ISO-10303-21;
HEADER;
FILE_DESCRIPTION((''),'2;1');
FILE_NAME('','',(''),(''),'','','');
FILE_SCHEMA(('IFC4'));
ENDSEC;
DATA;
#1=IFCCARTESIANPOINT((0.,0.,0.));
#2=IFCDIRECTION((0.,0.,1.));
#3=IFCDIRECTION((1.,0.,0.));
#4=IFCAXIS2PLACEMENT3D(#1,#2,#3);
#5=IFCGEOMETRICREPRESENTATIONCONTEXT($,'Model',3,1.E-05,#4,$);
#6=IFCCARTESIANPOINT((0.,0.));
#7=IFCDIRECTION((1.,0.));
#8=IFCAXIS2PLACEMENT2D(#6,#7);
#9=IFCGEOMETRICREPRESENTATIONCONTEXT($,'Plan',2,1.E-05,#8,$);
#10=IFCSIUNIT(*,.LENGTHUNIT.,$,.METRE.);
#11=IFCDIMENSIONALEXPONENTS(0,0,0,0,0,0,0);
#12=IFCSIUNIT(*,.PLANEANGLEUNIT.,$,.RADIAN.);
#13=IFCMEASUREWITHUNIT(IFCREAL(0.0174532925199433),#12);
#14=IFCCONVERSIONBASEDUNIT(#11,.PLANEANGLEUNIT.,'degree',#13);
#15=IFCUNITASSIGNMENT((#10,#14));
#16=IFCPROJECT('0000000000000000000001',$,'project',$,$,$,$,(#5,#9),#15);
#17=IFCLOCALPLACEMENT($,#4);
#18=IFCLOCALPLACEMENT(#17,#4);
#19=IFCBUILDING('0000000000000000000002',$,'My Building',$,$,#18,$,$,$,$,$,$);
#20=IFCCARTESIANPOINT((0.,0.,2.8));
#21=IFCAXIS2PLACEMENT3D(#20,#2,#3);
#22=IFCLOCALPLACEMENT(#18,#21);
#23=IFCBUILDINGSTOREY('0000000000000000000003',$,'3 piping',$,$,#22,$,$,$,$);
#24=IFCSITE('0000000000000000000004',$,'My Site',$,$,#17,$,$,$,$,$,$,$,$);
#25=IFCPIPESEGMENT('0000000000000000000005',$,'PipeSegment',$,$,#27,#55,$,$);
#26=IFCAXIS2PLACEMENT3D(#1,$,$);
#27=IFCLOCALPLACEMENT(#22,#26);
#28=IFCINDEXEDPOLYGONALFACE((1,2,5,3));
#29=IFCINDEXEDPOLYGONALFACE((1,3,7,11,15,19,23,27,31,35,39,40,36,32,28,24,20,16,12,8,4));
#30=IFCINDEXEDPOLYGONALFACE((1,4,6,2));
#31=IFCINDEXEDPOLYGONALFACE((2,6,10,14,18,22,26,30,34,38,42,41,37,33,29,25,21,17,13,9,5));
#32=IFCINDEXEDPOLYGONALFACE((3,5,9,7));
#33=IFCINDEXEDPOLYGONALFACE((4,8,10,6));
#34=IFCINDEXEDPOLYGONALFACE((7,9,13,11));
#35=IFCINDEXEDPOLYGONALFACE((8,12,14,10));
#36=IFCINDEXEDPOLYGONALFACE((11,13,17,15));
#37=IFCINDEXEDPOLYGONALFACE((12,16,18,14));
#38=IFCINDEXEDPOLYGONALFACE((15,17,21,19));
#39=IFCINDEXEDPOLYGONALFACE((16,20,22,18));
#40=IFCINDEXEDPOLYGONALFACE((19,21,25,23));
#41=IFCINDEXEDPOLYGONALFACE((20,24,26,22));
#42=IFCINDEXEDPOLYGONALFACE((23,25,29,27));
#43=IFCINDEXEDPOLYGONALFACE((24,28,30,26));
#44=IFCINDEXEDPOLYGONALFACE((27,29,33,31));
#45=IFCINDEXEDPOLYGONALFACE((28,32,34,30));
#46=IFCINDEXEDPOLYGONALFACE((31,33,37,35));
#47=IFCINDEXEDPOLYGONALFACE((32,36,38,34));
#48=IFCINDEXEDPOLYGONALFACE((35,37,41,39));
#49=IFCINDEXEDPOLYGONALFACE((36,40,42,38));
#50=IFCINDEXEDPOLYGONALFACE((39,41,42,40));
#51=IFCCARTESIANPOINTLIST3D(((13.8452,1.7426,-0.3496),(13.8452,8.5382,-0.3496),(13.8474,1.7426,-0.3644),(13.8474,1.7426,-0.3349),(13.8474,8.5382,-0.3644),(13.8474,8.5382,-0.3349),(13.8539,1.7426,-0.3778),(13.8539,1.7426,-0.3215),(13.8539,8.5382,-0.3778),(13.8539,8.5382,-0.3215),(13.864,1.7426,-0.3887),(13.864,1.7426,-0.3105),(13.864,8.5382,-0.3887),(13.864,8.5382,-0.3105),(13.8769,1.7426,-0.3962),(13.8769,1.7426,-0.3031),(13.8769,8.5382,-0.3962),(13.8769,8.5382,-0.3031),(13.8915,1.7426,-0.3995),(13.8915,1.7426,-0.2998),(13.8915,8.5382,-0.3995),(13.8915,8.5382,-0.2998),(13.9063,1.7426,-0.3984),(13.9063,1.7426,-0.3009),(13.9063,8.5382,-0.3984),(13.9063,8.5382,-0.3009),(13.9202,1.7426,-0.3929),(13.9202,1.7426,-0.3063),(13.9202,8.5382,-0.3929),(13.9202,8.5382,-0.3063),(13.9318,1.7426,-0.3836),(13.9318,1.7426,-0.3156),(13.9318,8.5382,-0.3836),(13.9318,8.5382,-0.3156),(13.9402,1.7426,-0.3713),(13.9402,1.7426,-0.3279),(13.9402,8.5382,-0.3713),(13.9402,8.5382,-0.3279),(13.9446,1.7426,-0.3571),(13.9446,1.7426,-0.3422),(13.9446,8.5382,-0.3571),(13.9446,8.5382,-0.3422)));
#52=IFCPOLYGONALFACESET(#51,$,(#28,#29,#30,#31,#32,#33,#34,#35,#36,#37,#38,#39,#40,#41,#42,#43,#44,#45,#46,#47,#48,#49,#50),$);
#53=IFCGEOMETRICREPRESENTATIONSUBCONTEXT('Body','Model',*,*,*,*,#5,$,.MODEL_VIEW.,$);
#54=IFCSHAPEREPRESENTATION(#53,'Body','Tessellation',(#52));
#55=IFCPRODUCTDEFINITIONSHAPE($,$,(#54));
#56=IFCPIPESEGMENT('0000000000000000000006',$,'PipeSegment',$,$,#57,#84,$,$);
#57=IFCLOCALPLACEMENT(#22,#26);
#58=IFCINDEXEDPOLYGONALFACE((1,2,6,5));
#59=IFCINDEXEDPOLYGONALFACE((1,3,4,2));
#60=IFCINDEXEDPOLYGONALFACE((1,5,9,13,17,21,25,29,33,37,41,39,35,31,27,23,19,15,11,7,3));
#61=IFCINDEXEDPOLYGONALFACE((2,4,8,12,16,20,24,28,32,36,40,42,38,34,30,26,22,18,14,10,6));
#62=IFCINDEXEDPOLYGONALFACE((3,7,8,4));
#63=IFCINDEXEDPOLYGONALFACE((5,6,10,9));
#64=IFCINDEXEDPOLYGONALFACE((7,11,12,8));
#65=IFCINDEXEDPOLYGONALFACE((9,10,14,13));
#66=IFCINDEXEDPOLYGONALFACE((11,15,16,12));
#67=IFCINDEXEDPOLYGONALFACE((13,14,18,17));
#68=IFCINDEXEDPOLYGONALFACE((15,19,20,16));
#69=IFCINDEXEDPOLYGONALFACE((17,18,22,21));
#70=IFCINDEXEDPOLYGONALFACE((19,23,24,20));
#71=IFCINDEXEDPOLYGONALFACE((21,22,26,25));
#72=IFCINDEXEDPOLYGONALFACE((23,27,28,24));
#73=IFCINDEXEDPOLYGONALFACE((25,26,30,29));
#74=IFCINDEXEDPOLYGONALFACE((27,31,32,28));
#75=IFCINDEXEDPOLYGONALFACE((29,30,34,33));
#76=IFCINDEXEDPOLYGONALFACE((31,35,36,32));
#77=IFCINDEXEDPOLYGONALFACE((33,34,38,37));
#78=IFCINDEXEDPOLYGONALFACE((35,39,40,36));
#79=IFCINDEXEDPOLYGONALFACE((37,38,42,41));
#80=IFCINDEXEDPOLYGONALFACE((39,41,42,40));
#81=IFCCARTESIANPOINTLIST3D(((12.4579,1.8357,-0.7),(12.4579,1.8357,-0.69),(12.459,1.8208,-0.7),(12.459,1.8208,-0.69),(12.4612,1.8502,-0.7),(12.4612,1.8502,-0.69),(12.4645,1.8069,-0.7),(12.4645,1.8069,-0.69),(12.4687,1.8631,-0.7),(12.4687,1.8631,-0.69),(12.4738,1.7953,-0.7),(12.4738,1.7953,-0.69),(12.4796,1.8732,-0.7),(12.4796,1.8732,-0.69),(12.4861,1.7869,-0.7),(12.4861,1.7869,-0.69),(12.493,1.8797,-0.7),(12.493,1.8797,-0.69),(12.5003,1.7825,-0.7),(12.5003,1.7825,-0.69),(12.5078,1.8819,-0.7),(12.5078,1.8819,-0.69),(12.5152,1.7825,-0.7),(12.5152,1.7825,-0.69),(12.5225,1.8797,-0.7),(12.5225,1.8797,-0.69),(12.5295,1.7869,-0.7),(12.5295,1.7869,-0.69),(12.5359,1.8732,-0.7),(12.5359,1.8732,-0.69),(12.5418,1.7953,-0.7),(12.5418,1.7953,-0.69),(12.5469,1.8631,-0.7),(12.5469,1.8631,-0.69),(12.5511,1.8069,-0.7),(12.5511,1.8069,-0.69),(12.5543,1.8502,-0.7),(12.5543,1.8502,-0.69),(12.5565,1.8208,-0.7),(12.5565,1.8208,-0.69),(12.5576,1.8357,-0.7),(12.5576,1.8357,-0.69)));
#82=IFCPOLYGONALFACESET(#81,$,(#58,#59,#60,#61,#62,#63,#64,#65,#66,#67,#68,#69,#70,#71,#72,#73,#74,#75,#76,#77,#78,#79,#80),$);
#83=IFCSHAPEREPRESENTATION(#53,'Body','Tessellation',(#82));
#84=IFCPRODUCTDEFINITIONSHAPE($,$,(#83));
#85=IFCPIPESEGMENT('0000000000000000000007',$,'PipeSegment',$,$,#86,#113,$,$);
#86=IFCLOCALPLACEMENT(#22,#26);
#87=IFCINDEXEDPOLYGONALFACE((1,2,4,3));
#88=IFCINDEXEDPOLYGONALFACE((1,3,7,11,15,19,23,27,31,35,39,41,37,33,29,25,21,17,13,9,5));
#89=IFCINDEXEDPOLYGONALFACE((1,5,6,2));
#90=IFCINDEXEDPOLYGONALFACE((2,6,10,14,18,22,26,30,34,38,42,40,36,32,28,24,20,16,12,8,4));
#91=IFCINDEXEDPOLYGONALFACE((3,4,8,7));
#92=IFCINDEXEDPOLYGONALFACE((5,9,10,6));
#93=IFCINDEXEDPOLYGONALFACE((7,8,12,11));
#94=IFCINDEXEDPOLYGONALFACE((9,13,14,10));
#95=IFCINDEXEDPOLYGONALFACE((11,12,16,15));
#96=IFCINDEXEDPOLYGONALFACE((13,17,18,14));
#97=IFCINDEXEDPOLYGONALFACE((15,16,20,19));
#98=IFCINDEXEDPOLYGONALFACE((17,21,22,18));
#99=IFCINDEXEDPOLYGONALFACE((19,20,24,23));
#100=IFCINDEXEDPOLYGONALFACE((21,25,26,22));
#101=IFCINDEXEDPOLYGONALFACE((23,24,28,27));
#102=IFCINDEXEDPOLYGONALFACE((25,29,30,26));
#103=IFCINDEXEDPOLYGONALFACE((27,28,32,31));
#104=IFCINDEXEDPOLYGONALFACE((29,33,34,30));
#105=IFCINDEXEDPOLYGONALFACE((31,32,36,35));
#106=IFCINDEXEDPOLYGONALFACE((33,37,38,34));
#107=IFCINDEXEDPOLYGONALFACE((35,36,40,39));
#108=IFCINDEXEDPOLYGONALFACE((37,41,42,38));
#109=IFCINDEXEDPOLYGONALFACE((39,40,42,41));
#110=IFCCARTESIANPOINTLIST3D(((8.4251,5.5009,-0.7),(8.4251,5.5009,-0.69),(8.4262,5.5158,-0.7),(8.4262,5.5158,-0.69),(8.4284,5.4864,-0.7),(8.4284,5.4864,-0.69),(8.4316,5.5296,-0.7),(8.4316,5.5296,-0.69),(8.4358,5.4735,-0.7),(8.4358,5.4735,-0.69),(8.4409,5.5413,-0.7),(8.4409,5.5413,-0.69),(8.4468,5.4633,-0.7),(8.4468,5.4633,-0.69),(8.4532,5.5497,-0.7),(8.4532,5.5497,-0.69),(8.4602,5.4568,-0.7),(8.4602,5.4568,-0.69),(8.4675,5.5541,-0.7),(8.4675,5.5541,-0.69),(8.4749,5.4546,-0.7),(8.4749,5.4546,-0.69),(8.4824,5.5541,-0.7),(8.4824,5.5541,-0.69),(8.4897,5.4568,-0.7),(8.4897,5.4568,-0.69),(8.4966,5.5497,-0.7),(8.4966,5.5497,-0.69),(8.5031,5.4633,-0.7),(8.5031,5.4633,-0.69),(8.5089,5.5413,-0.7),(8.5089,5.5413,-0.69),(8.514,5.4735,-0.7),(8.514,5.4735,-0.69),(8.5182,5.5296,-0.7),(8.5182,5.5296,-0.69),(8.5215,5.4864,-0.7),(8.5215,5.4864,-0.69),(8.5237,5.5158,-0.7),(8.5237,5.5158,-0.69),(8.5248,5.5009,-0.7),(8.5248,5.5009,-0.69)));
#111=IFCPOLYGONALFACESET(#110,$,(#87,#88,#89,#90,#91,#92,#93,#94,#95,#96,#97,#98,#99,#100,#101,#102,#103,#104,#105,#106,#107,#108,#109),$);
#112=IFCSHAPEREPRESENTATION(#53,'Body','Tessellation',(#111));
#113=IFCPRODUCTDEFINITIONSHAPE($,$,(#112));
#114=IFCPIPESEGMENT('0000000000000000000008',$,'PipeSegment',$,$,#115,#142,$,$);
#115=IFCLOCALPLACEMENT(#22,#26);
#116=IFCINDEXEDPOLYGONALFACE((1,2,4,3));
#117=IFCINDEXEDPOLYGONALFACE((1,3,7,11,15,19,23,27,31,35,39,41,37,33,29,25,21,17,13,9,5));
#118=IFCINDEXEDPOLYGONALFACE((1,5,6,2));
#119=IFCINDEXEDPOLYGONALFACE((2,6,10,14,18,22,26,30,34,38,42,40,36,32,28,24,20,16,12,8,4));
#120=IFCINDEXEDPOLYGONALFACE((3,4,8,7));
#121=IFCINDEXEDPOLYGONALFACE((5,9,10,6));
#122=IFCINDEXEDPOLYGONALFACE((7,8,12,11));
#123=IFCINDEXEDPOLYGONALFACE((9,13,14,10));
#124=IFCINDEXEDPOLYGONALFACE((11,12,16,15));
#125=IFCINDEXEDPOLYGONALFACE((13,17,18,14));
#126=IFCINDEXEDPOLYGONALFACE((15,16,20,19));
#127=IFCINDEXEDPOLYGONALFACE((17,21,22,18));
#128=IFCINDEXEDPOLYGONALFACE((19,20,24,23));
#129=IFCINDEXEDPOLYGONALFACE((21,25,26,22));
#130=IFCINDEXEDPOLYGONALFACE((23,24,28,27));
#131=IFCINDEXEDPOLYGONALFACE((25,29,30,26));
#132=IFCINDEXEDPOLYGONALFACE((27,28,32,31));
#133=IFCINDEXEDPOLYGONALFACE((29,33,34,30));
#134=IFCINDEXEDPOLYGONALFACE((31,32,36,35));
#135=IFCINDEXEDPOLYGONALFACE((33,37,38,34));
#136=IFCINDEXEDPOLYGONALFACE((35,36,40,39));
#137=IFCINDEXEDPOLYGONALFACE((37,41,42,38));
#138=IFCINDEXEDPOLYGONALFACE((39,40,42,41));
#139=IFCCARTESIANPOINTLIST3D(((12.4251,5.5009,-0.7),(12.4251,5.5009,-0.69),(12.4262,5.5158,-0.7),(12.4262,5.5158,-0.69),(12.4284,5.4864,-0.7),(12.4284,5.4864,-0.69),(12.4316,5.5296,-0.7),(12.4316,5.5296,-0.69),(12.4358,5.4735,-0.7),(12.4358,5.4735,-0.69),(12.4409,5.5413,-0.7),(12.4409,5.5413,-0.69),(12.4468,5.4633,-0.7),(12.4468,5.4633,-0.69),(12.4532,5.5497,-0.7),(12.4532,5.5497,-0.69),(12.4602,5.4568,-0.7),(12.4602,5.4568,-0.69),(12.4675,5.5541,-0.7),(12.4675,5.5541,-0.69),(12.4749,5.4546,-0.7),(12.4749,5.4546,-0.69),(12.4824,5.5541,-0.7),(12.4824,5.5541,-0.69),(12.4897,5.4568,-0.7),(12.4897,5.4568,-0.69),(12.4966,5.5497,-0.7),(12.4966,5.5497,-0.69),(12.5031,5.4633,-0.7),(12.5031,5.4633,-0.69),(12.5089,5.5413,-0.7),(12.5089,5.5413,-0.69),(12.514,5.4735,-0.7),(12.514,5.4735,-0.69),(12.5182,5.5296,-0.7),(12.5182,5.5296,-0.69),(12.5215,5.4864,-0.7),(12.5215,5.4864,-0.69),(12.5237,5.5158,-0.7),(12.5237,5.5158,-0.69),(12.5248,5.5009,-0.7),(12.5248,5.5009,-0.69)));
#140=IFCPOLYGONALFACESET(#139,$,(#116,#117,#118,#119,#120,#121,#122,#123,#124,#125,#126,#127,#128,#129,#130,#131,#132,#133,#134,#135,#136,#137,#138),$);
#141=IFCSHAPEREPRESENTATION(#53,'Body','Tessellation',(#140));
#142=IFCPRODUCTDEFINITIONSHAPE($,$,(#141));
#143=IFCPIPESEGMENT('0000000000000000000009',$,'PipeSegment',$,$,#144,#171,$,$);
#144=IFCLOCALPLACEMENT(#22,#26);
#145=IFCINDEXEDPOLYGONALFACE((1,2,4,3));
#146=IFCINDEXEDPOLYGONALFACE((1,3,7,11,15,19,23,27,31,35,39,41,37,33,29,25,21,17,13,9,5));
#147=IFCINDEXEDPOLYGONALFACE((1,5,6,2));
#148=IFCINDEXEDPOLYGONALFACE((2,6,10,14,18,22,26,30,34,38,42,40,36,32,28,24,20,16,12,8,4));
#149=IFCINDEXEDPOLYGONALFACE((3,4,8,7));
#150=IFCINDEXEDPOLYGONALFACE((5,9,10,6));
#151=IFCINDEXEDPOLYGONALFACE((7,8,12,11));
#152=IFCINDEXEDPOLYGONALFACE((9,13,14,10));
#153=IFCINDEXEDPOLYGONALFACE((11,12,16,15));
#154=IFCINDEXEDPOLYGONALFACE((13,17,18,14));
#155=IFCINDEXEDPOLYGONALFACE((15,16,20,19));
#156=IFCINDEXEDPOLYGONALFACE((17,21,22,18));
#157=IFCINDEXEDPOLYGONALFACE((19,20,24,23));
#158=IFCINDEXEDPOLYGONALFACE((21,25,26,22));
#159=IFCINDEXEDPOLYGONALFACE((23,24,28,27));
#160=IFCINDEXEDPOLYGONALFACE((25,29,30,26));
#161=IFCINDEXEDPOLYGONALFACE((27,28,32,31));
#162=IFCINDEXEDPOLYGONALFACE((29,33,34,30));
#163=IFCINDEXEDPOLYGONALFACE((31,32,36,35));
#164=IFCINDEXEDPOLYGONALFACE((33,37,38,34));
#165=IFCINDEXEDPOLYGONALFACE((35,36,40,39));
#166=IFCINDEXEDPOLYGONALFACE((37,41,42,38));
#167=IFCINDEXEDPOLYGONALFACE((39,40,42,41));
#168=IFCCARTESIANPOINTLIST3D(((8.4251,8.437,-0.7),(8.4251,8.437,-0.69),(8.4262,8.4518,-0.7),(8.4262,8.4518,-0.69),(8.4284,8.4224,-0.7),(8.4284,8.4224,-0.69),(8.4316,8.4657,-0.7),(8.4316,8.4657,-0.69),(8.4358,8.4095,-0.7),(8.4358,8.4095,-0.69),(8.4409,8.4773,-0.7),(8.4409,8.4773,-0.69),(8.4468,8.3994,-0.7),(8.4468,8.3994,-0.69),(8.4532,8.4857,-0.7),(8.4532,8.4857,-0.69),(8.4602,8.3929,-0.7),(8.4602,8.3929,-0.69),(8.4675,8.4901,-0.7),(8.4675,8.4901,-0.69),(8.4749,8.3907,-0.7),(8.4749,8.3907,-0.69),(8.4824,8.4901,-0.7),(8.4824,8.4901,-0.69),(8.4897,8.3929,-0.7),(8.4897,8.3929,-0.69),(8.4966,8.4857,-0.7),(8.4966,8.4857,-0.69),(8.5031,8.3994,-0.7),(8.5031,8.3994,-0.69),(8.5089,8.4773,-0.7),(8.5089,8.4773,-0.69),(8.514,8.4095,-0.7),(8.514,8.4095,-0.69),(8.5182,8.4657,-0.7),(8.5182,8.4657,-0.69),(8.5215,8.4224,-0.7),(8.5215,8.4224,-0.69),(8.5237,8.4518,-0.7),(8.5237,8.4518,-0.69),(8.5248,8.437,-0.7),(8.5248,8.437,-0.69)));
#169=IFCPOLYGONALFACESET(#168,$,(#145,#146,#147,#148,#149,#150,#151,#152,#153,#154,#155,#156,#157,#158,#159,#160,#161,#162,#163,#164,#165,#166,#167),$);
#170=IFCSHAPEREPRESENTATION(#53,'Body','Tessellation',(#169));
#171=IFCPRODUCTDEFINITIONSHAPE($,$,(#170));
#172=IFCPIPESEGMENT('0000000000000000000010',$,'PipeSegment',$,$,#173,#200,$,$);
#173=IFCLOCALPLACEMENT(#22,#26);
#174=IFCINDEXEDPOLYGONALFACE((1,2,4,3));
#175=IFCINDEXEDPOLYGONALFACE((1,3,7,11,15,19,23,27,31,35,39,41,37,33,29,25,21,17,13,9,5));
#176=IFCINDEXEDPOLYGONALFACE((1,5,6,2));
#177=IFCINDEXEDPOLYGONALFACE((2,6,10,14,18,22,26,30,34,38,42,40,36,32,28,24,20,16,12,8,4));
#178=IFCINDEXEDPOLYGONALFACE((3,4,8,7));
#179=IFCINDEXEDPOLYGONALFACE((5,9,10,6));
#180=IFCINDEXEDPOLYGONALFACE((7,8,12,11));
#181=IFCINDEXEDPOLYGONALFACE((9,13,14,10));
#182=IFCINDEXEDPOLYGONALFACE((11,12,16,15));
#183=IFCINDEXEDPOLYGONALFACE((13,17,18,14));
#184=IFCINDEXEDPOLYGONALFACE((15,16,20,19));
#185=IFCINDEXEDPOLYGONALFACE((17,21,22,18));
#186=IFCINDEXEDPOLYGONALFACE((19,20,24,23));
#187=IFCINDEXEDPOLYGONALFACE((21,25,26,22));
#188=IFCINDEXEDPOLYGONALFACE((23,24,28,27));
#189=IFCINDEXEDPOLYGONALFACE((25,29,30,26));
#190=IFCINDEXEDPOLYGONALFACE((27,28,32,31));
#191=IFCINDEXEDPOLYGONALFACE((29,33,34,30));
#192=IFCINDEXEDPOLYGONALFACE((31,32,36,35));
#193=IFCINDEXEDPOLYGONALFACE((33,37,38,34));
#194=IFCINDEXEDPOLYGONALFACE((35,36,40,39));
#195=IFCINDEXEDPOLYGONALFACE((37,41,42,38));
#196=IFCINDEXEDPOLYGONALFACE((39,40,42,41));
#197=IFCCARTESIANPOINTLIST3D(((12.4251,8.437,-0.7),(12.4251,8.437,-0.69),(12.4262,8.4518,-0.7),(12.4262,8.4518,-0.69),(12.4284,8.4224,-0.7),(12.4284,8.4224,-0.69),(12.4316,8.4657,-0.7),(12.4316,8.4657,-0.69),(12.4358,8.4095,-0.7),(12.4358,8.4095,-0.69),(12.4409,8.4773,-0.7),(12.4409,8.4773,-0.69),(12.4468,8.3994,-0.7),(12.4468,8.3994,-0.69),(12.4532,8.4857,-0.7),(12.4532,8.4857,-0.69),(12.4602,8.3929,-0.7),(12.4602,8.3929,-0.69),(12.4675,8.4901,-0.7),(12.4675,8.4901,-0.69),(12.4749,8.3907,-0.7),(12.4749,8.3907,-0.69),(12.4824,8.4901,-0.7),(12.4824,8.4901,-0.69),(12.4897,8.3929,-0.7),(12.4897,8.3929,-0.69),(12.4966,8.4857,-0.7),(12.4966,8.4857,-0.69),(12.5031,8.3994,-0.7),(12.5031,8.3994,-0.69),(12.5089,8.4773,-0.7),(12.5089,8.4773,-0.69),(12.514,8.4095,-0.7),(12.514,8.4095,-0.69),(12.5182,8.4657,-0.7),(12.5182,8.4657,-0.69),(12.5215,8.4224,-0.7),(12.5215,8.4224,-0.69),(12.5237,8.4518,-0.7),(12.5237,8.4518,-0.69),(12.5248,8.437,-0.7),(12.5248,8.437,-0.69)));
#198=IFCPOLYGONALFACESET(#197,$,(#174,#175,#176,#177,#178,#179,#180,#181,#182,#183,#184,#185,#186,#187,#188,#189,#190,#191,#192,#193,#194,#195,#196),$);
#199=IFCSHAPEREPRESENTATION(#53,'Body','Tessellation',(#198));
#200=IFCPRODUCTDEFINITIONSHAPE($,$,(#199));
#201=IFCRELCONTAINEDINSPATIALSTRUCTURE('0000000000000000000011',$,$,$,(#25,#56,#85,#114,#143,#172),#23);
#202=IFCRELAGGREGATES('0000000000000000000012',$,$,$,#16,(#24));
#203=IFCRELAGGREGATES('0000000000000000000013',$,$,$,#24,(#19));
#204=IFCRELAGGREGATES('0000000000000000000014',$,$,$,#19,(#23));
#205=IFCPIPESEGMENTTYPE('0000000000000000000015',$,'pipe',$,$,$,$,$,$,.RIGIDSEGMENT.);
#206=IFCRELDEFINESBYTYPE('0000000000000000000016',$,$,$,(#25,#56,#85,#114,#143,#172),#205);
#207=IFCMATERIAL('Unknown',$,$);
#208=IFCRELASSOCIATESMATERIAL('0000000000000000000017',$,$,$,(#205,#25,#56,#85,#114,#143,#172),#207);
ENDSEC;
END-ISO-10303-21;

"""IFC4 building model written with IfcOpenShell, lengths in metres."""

from ifc_helpers import new_model, entity, si_unit, converted_unit, frame, origin_with_axes, origin_2d_with_axis, place, context, subcontext, project, spatial, circle, extrude, material, material_profile, profile_set, profile_usage, type_object, element, save


model = new_model("IFC4")

# Units and contexts
model_context = context("Model", 3, precision=1e-05, world=origin_with_axes())
plan_context = context("Plan", 2, precision=1e-05, world=origin_2d_with_axis())
body_context = subcontext(model_context, "Body", "Model", "MODEL_VIEW")
ifc_project = project(units=[si_unit("LENGTHUNIT", "METRE"), converted_unit("PLANEANGLEUNIT", "degree", entity("IfcReal", 0.0174532925199433), si_unit("PLANEANGLEUNIT", "RADIAN"), dimensions=[0, 0, 0, 0, 0, 0, 0])], contexts=[model_context, plan_context])

# Site, building, storey
site_placement = place(None, origin_with_axes())
site = spatial("IfcSite", under=ifc_project, at=site_placement, Name="My Site")
building_placement = place(site_placement, origin_with_axes())
building = spatial("IfcBuilding", under=site, at=building_placement, Name="My Building")
storey_placement = place(building_placement, frame((0.0, 0.0, 2.8), z_axis=(0.0, 0.0, 1.0), x_axis=(1.0, 0.0, 0.0)))
storey = spatial("IfcBuildingStorey", under=building, at=storey_placement, Name="3 piping")

# Pipe segments
ifc_material = material(Name="Unknown")
ifc_material_profile_1 = material_profile(ifc_material, circle(Radius=0.05))
ifc_profile_set_1 = profile_set([ifc_material_profile_1])
ifc_profile_usage_1 = profile_usage(ifc_profile_set_1, cardinal=2)
pipe_segment_type = type_object("IfcPipeSegmentType", Name="pipe", PredefinedType="RIGIDSEGMENT", material=ifc_profile_set_1)
pipe_segment_1_placement = place(storey_placement, frame((13.8952, 1.7426, -0.3996), z_axis=(0.0, 1.0, 0.0), x_axis=(-1.0, 0.0, 0.0)))
element("IfcPipeSegment", 1, at=pipe_segment_1_placement, inside=storey, type_object=pipe_segment_type, material=ifc_profile_usage_1, Name="PipeSegment", context=body_context, shape_type="SweptSolid", body=[
    extrude(circle(Radius=0.05), frame((0.0, 0.05, 0.0), z_axis=(0.0, 0.0, 1.0), x_axis=(1.0, 0.0, 0.0)), (0.0, 0.0, 1.0), 6.7956),
])
ifc_profile_usage_2 = profile_usage(ifc_profile_set_1, cardinal=2)
pipe_segment_2_placement = place(storey_placement, frame((12.4578, 1.8319, -0.69), z_axis=(0.0, 0.0, -1.0), x_axis=(0.0, 1.0, 0.0)))
element("IfcPipeSegment", 2, at=pipe_segment_2_placement, inside=storey, type_object=pipe_segment_type, material=ifc_profile_usage_2, Name="PipeSegment", context=body_context, shape_type="SweptSolid", body=[
    extrude(circle(Radius=0.05), frame((0.0, 0.05, 0.0), z_axis=(0.0, 0.0, 1.0), x_axis=(1.0, 0.0, 0.0)), (0.0, 0.0, 1.0), 0.01),
])
ifc_profile_usage_3 = profile_usage(ifc_profile_set_1, cardinal=2)
pipe_segment_3_placement = place(storey_placement, frame((8.5249, 5.5046, -0.69), z_axis=(0.0, 0.0, -1.0), x_axis=(0.0, -1.0, 0.0)))
element("IfcPipeSegment", 3, at=pipe_segment_3_placement, inside=storey, type_object=pipe_segment_type, material=ifc_profile_usage_3, Name="PipeSegment", context=body_context, shape_type="SweptSolid", body=[
    extrude(circle(Radius=0.05), frame((0.0, 0.05, 0.0), z_axis=(0.0, 0.0, 1.0), x_axis=(1.0, 0.0, 0.0)), (0.0, 0.0, 1.0), 0.01),
])
ifc_profile_usage_4 = profile_usage(ifc_profile_set_1, cardinal=2)
pipe_segment_4_placement = place(storey_placement, frame((12.5249, 5.5046, -0.69), z_axis=(0.0, 0.0, -1.0), x_axis=(0.0, -1.0, 0.0)))
element("IfcPipeSegment", 4, at=pipe_segment_4_placement, inside=storey, type_object=pipe_segment_type, material=ifc_profile_usage_4, Name="PipeSegment", context=body_context, shape_type="SweptSolid", body=[
    extrude(circle(Radius=0.05), frame((0.0, 0.05, 0.0), z_axis=(0.0, 0.0, 1.0), x_axis=(1.0, 0.0, 0.0)), (0.0, 0.0, 1.0), 0.01),
])
ifc_profile_usage_5 = profile_usage(ifc_profile_set_1, cardinal=2)
pipe_segment_5_placement = place(storey_placement, frame((8.5249, 8.4407, -0.69), z_axis=(0.0, 0.0, -1.0), x_axis=(0.0, -1.0, 0.0)))
element("IfcPipeSegment", 5, at=pipe_segment_5_placement, inside=storey, type_object=pipe_segment_type, material=ifc_profile_usage_5, Name="PipeSegment", context=body_context, shape_type="SweptSolid", body=[
    extrude(circle(Radius=0.05), frame((0.0, 0.05, 0.0), z_axis=(0.0, 0.0, 1.0), x_axis=(1.0, 0.0, 0.0)), (0.0, 0.0, 1.0), 0.01),
])
ifc_profile_usage_6 = profile_usage(ifc_profile_set_1, cardinal=2)
pipe_segment_6_placement = place(storey_placement, frame((12.5249, 8.4407, -0.69), z_axis=(0.0, 0.0, -1.0), x_axis=(0.0, -1.0, 0.0)))
element("IfcPipeSegment", 6, at=pipe_segment_6_placement, inside=storey, type_object=pipe_segment_type, material=ifc_profile_usage_6, Name="PipeSegment", context=body_context, shape_type="SweptSolid", body=[
    extrude(circle(Radius=0.05), frame((0.0, 0.05, 0.0), z_axis=(0.0, 0.0, 1.0), x_axis=(1.0, 0.0, 0.0)), (0.0, 0.0, 1.0), 0.01),
])

save(model, "model.ifc")
